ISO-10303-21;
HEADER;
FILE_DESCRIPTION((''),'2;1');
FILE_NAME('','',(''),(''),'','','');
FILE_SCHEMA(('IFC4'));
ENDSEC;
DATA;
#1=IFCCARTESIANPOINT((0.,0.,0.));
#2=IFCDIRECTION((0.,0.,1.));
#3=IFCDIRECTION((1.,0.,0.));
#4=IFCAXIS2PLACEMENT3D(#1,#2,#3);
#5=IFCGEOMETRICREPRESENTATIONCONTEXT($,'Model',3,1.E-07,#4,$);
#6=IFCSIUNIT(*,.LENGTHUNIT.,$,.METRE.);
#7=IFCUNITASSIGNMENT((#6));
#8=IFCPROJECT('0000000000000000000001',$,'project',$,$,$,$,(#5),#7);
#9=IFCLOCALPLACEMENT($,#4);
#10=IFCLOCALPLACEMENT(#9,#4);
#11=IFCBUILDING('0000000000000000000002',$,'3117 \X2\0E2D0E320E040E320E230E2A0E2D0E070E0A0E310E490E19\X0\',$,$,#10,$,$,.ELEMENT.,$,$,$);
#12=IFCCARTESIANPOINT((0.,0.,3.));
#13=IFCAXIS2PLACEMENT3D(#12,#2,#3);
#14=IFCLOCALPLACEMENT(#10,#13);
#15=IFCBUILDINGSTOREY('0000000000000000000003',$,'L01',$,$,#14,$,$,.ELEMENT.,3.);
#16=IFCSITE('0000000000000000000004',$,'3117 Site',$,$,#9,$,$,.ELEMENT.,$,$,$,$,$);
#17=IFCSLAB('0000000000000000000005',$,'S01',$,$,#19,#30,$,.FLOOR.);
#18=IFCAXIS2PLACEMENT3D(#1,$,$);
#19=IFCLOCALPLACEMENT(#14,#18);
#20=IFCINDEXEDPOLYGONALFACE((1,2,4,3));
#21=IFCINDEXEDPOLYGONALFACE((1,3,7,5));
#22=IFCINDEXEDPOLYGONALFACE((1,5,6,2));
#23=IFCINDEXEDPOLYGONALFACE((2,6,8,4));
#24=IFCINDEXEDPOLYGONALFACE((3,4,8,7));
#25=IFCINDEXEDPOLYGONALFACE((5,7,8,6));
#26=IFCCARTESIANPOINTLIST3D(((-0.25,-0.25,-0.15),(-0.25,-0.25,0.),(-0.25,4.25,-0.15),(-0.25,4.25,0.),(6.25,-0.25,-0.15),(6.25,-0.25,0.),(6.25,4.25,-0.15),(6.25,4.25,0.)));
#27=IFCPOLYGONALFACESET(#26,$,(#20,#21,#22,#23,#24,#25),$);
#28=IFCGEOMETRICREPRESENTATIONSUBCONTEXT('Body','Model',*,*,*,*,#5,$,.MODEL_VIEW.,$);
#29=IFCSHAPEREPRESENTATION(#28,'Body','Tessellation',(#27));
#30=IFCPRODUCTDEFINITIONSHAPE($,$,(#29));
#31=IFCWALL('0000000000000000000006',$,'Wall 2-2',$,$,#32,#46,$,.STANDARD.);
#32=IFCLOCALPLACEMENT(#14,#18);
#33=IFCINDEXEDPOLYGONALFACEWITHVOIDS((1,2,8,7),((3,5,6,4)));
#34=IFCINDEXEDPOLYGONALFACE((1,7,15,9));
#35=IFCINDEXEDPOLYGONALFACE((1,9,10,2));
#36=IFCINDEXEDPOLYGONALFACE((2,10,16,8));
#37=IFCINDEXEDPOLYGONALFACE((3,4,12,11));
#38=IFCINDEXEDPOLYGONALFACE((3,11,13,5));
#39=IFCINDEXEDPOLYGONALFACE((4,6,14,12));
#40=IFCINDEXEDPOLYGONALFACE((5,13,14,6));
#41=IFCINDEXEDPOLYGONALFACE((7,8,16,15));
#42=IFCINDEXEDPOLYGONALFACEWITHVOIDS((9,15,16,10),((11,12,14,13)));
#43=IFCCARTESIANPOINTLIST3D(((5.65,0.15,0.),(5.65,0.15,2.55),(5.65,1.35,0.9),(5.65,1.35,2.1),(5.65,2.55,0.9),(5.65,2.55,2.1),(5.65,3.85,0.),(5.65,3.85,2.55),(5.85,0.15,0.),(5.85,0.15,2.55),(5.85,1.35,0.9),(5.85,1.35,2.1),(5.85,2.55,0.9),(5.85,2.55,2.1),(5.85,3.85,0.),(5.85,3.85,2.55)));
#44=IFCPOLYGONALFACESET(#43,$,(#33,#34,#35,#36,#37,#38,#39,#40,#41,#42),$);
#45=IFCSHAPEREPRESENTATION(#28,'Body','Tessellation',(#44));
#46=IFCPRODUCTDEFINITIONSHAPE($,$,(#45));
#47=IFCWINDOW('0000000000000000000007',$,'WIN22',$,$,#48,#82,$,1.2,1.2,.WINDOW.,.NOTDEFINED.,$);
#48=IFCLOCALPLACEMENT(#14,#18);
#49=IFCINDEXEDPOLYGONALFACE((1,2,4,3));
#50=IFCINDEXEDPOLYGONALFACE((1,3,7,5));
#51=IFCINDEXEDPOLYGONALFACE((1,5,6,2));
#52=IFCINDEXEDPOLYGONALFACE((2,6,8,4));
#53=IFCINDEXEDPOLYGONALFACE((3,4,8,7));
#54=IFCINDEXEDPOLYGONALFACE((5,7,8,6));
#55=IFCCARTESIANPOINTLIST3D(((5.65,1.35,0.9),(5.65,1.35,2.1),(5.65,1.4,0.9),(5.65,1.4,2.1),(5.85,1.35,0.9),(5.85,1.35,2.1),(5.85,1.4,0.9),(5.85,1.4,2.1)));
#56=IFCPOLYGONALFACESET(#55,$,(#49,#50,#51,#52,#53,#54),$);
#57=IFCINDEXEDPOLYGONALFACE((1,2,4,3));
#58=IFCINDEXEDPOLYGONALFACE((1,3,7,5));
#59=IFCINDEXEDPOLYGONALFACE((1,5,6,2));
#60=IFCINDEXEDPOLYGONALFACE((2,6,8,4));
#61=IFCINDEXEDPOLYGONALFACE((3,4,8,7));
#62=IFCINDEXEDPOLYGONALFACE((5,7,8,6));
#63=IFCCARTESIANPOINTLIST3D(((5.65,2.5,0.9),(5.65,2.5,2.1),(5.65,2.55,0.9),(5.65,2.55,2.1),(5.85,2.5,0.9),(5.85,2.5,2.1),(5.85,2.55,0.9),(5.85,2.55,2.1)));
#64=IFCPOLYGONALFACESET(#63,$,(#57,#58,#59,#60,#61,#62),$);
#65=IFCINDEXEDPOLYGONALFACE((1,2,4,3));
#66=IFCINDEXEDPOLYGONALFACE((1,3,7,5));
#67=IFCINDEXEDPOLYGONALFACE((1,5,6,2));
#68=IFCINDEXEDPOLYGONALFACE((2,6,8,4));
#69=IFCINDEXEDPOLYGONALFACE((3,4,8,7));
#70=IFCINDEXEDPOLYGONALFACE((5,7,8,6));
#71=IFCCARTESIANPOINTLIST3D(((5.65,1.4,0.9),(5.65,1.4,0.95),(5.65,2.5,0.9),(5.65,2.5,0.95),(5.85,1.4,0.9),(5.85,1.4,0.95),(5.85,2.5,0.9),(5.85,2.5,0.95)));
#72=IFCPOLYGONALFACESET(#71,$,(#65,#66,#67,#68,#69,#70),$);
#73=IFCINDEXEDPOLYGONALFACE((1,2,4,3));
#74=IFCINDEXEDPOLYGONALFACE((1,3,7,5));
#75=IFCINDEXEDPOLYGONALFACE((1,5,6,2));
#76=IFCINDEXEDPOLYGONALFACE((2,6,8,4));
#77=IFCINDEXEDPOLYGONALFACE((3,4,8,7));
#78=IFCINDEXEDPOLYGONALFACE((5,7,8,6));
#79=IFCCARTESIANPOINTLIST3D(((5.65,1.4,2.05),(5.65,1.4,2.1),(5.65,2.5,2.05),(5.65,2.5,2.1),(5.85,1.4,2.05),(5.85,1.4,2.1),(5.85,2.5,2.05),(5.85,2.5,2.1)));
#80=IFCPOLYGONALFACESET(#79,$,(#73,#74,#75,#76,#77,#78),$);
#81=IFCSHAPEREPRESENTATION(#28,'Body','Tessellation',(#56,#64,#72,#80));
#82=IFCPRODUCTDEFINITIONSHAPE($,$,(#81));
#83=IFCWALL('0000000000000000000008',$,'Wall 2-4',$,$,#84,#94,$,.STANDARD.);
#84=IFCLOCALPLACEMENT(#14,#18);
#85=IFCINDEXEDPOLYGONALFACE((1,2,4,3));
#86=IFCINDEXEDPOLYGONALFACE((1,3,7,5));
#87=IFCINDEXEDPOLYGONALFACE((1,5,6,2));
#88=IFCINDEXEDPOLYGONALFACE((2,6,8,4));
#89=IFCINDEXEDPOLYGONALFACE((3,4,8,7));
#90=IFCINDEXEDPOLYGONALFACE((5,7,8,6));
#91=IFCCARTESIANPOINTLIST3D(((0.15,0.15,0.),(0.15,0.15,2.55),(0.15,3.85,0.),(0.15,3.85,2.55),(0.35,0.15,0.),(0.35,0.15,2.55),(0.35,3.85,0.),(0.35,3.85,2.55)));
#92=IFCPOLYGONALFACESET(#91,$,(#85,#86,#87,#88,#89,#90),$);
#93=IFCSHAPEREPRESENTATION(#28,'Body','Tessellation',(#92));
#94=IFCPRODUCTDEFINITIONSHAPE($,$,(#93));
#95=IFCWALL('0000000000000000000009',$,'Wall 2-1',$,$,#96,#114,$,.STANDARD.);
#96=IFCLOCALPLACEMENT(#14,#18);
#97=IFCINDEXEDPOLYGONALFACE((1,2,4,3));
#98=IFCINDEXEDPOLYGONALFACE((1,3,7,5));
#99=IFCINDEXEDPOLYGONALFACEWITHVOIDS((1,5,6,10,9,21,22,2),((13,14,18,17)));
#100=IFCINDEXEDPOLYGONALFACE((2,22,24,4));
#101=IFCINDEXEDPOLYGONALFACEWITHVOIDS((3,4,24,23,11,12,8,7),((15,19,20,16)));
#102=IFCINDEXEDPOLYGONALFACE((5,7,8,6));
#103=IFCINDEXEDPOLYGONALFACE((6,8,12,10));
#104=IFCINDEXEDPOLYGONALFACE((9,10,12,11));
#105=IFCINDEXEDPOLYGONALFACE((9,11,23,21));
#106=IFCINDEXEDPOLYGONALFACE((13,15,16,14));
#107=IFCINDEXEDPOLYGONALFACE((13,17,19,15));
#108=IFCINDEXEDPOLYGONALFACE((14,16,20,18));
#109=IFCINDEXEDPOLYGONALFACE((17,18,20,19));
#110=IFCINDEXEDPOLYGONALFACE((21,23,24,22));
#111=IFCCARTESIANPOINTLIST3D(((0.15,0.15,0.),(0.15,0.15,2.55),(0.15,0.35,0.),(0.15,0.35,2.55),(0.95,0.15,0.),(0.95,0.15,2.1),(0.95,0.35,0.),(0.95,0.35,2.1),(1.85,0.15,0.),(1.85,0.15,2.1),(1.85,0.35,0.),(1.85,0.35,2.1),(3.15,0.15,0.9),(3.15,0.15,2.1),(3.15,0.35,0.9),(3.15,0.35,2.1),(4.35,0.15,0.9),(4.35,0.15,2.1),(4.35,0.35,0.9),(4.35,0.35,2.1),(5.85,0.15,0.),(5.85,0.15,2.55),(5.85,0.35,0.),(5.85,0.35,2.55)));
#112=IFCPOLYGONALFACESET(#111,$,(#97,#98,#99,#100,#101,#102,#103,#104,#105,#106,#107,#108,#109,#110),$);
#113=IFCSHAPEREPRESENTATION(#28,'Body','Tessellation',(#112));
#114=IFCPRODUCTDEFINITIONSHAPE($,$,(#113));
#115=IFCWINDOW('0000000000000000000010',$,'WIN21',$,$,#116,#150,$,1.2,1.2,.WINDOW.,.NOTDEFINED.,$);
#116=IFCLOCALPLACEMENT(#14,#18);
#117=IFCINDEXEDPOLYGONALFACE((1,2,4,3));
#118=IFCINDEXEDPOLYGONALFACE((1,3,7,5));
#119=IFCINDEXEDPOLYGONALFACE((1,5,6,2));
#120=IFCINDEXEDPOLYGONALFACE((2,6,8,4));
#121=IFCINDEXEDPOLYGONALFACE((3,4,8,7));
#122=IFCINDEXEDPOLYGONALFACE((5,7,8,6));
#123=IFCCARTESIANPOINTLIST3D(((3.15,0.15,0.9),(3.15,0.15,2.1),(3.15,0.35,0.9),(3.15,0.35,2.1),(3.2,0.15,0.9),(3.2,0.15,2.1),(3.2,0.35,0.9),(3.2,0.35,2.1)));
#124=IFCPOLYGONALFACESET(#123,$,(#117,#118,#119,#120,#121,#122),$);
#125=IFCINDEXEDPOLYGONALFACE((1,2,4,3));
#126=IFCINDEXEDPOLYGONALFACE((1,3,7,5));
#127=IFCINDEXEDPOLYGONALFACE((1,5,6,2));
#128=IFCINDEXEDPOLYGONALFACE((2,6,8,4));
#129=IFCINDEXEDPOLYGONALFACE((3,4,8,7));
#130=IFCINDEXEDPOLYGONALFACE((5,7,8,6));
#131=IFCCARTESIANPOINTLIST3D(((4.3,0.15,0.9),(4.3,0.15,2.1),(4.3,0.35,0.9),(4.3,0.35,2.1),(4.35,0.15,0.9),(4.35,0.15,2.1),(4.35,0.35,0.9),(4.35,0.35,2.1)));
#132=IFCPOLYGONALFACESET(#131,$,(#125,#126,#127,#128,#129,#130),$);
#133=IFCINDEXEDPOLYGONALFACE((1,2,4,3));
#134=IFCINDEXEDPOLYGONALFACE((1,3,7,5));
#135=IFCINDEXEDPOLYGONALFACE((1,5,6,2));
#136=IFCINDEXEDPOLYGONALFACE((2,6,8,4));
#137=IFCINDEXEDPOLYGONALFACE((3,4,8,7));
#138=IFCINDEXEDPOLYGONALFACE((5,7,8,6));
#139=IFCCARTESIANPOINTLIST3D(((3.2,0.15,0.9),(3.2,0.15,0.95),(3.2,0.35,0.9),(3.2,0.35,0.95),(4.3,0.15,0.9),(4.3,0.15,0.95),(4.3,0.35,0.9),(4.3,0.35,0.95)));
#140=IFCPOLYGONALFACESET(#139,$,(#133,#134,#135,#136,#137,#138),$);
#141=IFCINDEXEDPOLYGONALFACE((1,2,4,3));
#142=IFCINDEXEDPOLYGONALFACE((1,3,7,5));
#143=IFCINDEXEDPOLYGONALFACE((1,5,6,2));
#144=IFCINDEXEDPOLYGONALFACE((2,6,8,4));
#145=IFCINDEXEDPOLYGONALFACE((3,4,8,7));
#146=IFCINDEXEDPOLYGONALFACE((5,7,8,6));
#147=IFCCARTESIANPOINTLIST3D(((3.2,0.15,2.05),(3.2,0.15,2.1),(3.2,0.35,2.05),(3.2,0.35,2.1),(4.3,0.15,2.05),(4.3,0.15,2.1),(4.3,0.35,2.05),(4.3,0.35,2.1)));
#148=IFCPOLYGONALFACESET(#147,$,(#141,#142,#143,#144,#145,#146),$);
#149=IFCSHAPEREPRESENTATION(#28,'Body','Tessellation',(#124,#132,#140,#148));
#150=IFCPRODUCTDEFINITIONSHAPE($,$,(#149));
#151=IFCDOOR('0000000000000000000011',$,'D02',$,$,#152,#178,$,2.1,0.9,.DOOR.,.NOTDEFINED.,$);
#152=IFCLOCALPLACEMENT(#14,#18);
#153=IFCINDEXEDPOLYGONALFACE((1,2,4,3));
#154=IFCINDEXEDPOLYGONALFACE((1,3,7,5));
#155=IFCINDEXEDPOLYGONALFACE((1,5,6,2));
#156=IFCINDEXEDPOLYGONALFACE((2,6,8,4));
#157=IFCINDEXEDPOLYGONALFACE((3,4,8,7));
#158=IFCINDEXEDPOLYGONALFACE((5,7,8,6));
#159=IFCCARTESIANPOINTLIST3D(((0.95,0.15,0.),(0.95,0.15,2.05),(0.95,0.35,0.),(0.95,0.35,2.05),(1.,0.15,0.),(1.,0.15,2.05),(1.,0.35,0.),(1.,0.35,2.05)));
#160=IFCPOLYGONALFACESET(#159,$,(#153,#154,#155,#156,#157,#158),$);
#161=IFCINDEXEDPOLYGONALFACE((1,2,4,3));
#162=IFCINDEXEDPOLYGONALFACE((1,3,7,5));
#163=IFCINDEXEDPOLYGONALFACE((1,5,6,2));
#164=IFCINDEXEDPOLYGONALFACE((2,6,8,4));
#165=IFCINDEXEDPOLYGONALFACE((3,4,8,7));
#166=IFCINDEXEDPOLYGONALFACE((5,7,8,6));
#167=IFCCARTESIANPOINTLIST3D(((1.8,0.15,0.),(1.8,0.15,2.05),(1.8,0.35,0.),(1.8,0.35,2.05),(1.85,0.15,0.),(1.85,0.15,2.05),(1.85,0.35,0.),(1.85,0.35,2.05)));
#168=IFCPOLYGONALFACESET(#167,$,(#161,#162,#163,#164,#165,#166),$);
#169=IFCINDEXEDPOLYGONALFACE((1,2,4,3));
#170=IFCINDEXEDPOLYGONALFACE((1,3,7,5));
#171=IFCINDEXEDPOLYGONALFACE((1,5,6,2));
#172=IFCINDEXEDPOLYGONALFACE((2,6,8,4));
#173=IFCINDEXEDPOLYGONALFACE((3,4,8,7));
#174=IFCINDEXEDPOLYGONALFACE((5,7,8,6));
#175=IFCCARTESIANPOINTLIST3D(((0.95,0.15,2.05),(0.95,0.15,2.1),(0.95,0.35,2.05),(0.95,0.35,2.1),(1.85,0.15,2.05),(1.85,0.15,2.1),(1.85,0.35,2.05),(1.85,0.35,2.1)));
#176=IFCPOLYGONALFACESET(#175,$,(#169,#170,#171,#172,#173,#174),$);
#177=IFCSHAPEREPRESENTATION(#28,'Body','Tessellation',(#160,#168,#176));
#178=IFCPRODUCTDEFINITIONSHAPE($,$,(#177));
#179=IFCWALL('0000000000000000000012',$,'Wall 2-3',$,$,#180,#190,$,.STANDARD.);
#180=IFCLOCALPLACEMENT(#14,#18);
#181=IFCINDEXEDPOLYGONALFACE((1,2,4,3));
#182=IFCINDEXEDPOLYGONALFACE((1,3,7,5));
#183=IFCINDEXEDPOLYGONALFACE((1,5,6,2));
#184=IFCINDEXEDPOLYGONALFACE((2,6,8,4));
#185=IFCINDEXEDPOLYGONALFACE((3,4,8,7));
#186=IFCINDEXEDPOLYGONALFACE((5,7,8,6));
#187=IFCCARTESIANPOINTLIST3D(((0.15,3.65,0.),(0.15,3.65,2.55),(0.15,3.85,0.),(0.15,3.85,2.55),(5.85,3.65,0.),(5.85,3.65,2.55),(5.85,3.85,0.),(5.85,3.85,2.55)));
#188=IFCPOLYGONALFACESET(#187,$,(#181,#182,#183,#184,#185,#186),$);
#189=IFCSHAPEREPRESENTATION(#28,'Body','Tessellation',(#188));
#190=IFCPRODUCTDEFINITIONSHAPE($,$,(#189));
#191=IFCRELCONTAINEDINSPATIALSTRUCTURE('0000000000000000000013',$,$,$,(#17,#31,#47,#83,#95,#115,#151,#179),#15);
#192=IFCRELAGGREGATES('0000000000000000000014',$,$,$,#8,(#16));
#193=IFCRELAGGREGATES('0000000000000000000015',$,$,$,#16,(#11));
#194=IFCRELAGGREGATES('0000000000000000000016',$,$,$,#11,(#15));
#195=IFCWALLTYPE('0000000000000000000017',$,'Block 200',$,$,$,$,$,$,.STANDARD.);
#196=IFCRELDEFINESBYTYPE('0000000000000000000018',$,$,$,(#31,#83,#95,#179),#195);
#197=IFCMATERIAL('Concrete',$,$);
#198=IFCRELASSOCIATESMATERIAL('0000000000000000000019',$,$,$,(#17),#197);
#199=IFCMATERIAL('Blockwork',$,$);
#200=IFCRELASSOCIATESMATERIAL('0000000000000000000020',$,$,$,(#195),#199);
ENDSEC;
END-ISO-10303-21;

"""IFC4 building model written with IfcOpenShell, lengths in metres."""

from ifc_helpers import new_model, si_unit, frame, origin_with_axes, place, context, subcontext, project, spatial, polyline, outline, extrude, material, type_object, element, fill, save


model = new_model("IFC4")

# Units and contexts
model_context = context("Model", 3, precision=1e-07, world=origin_with_axes())
body_context = subcontext(model_context, "Body", "Model", "MODEL_VIEW")
ifc_project = project(units=[si_unit("LENGTHUNIT", "METRE")], contexts=[model_context])

# Site, building, storey
site_placement = place(None, origin_with_axes())
site = spatial("IfcSite", under=ifc_project, at=site_placement, Name="3117 Site", CompositionType="ELEMENT")
building_placement = place(site_placement, origin_with_axes())
building = spatial("IfcBuilding", under=site, at=building_placement, Name="3117 อาคารสองชั้น", CompositionType="ELEMENT")
storey_placement = place(building_placement, frame((0.0, 0.0, 3.0), z_axis=(0.0, 0.0, 1.0), x_axis=(1.0, 0.0, 0.0)))
storey = spatial("IfcBuildingStorey", under=building, at=storey_placement, Name="L01", CompositionType="ELEMENT", Elevation=3.0)

# Slab
ifc_material_1 = material(Name="Concrete")
slab_placement = place(storey_placement, frame((0.0, 0.0, -0.15), z_axis=(0.0, 0.0, 1.0), x_axis=(1.0, 0.0, 0.0)))
element("IfcSlab", 1, at=slab_placement, inside=storey, material=ifc_material_1, Name="S01", PredefinedType="FLOOR", context=body_context, shape_type="SweptSolid", body=[
    extrude(outline(polyline([(-0.25, -0.25), (6.25, -0.25), (6.25, 4.25), (-0.25, 4.25), (-0.25, -0.25)])), origin_with_axes(), (0.0, 0.0, 1.0), 0.15),
])

# Wall, opening, window
ifc_material_2 = material(Name="Blockwork")
wall_type = type_object("IfcWallType", Name="Block 200", PredefinedType="STANDARD", material=ifc_material_2)
wall_1_placement = place(storey_placement, frame((5.85, 0.15, 0.0), z_axis=(0.0, 0.0, 1.0), x_axis=(0.0, 1.0, 0.0)))
wall_1 = element("IfcWall", 2, at=wall_1_placement, inside=storey, type_object=wall_type, Name="Wall 2-2", PredefinedType="STANDARD", context=body_context, shape_type="SweptSolid", body=[
    extrude(outline(polyline([(0.0, 0.0), (3.7, 0.0), (3.7, 0.2), (0.0, 0.2), (0.0, 0.0)])), origin_with_axes(), (0.0, 0.0, 1.0), 2.55),
])
opening_1_placement = place(wall_1_placement, frame((1.2, 0.0, 0.9), z_axis=(0.0, 0.0, 1.0), x_axis=(1.0, 0.0, 0.0)))
opening_1 = element("IfcOpeningElement", 3, at=opening_1_placement, cuts=wall_1, PredefinedType="OPENING", context=body_context, shape_type="SweptSolid", body=[
    extrude(outline(polyline([(0.0, 0.0), (1.2, 0.0), (1.2, 0.2), (0.0, 0.2), (0.0, 0.0)])), origin_with_axes(), (0.0, 0.0, 1.0), 1.2),
])
window_1_placement = place(opening_1_placement, frame((0.0, 0.0, 0.0), z_axis=(0.0, 0.0, 1.0), x_axis=(1.0, 0.0, 0.0)))
window_1 = element("IfcWindow", 4, at=window_1_placement, inside=storey, Name="WIN22", OverallHeight=1.2, OverallWidth=1.2, PartitioningType="NOTDEFINED", PredefinedType="WINDOW", context=body_context, shape_type="SweptSolid", body=[
    extrude(outline(polyline([(0.0, 0.0), (0.05, 0.0), (0.05, 0.2), (0.0, 0.2), (0.0, 0.0)])), origin_with_axes(), (0.0, 0.0, 1.0), 1.2),
    extrude(outline(polyline([(0.0, 0.0), (0.05, 0.0), (0.05, 0.2), (0.0, 0.2), (0.0, 0.0)])), frame((1.15, 0.0, 0.0), z_axis=(0.0, 0.0, 1.0), x_axis=(1.0, 0.0, 0.0)), (0.0, 0.0, 1.0), 1.2),
    extrude(outline(polyline([(0.0, 0.0), (1.1, 0.0), (1.1, 0.2), (0.0, 0.2), (0.0, 0.0)])), frame((0.05, 0.0, 0.0), z_axis=(0.0, 0.0, 1.0), x_axis=(1.0, 0.0, 0.0)), (0.0, 0.0, 1.0), 0.05),
    extrude(outline(polyline([(0.0, 0.0), (1.1, 0.0), (1.1, 0.2), (0.0, 0.2), (0.0, 0.0)])), frame((0.05, 0.0, 1.15), z_axis=(0.0, 0.0, 1.0), x_axis=(1.0, 0.0, 0.0)), (0.0, 0.0, 1.0), 0.05),
])
fill(opening_1, window_1)

# Wall
wall_2_placement = place(storey_placement, frame((0.15, 3.85, 0.0), z_axis=(0.0, 0.0, 1.0), x_axis=(0.0, -1.0, 0.0)))
element("IfcWall", 5, at=wall_2_placement, inside=storey, type_object=wall_type, Name="Wall 2-4", PredefinedType="STANDARD", context=body_context, shape_type="SweptSolid", body=[
    extrude(outline(polyline([(0.0, 0.0), (3.7, 0.0), (3.7, 0.2), (0.0, 0.2), (0.0, 0.0)])), origin_with_axes(), (0.0, 0.0, 1.0), 2.55),
])

# Wall, openings, window, door
wall_3_placement = place(storey_placement, frame((0.15, 0.15, 0.0), z_axis=(0.0, 0.0, 1.0), x_axis=(1.0, 0.0, 0.0)))
wall_3 = element("IfcWall", 6, at=wall_3_placement, inside=storey, type_object=wall_type, Name="Wall 2-1", PredefinedType="STANDARD", context=body_context, shape_type="SweptSolid", body=[
    extrude(outline(polyline([(0.0, 0.0), (5.7, 0.0), (5.7, 0.2), (0.0, 0.2), (0.0, 0.0)])), origin_with_axes(), (0.0, 0.0, 1.0), 2.55),
])
opening_2_placement = place(wall_3_placement, frame((3.0, 0.0, 0.9), z_axis=(0.0, 0.0, 1.0), x_axis=(1.0, 0.0, 0.0)))
opening_2 = element("IfcOpeningElement", 7, at=opening_2_placement, cuts=wall_3, PredefinedType="OPENING", context=body_context, shape_type="SweptSolid", body=[
    extrude(outline(polyline([(0.0, 0.0), (1.2, 0.0), (1.2, 0.2), (0.0, 0.2), (0.0, 0.0)])), origin_with_axes(), (0.0, 0.0, 1.0), 1.2),
])
opening_3_placement = place(wall_3_placement, frame((0.8, 0.0, 0.0), z_axis=(0.0, 0.0, 1.0), x_axis=(1.0, 0.0, 0.0)))
opening_3 = element("IfcOpeningElement", 8, at=opening_3_placement, cuts=wall_3, PredefinedType="OPENING", context=body_context, shape_type="SweptSolid", body=[
    extrude(outline(polyline([(0.0, 0.0), (0.9, 0.0), (0.9, 0.2), (0.0, 0.2), (0.0, 0.0)])), origin_with_axes(), (0.0, 0.0, 1.0), 2.1),
])
window_2_placement = place(opening_2_placement, frame((0.0, 0.0, 0.0), z_axis=(0.0, 0.0, 1.0), x_axis=(1.0, 0.0, 0.0)))
window_2 = element("IfcWindow", 9, at=window_2_placement, inside=storey, Name="WIN21", OverallHeight=1.2, OverallWidth=1.2, PartitioningType="NOTDEFINED", PredefinedType="WINDOW", context=body_context, shape_type="SweptSolid", body=[
    extrude(outline(polyline([(0.0, 0.0), (0.05, 0.0), (0.05, 0.2), (0.0, 0.2), (0.0, 0.0)])), origin_with_axes(), (0.0, 0.0, 1.0), 1.2),
    extrude(outline(polyline([(0.0, 0.0), (0.05, 0.0), (0.05, 0.2), (0.0, 0.2), (0.0, 0.0)])), frame((1.15, 0.0, 0.0), z_axis=(0.0, 0.0, 1.0), x_axis=(1.0, 0.0, 0.0)), (0.0, 0.0, 1.0), 1.2),
    extrude(outline(polyline([(0.0, 0.0), (1.1, 0.0), (1.1, 0.2), (0.0, 0.2), (0.0, 0.0)])), frame((0.05, 0.0, 0.0), z_axis=(0.0, 0.0, 1.0), x_axis=(1.0, 0.0, 0.0)), (0.0, 0.0, 1.0), 0.05),
    extrude(outline(polyline([(0.0, 0.0), (1.1, 0.0), (1.1, 0.2), (0.0, 0.2), (0.0, 0.0)])), frame((0.05, 0.0, 1.15), z_axis=(0.0, 0.0, 1.0), x_axis=(1.0, 0.0, 0.0)), (0.0, 0.0, 1.0), 0.05),
])
fill(opening_2, window_2)
door_placement = place(opening_3_placement, frame((0.0, 0.0, 0.0), z_axis=(0.0, 0.0, 1.0), x_axis=(1.0, 0.0, 0.0)))
door = element("IfcDoor", 10, at=door_placement, inside=storey, Name="D02", OperationType="NOTDEFINED", OverallHeight=2.1, OverallWidth=0.9, PredefinedType="DOOR", context=body_context, shape_type="SweptSolid", body=[
    extrude(outline(polyline([(0.0, 0.0), (0.05, 0.0), (0.05, 0.2), (0.0, 0.2), (0.0, 0.0)])), origin_with_axes(), (0.0, 0.0, 1.0), 2.05),
    extrude(outline(polyline([(0.0, 0.0), (0.05, 0.0), (0.05, 0.2), (0.0, 0.2), (0.0, 0.0)])), frame((0.85, 0.0, 0.0), z_axis=(0.0, 0.0, 1.0), x_axis=(1.0, 0.0, 0.0)), (0.0, 0.0, 1.0), 2.05),
    extrude(outline(polyline([(0.0, 0.0), (0.9, 0.0), (0.9, 0.2), (0.0, 0.2), (0.0, 0.0)])), frame((0.0, 0.0, 2.05), z_axis=(0.0, 0.0, 1.0), x_axis=(1.0, 0.0, 0.0)), (0.0, 0.0, 1.0), 0.05),
])
fill(opening_3, door)

# Wall
wall_4_placement = place(storey_placement, frame((5.85, 3.85, 0.0), z_axis=(0.0, 0.0, 1.0), x_axis=(-1.0, 0.0, 0.0)))
element("IfcWall", 11, at=wall_4_placement, inside=storey, type_object=wall_type, Name="Wall 2-3", PredefinedType="STANDARD", context=body_context, shape_type="SweptSolid", body=[
    extrude(outline(polyline([(0.0, 0.0), (5.7, 0.0), (5.7, 0.2), (0.0, 0.2), (0.0, 0.0)])), origin_with_axes(), (0.0, 0.0, 1.0), 2.55),
])

save(model, "model.ifc")
